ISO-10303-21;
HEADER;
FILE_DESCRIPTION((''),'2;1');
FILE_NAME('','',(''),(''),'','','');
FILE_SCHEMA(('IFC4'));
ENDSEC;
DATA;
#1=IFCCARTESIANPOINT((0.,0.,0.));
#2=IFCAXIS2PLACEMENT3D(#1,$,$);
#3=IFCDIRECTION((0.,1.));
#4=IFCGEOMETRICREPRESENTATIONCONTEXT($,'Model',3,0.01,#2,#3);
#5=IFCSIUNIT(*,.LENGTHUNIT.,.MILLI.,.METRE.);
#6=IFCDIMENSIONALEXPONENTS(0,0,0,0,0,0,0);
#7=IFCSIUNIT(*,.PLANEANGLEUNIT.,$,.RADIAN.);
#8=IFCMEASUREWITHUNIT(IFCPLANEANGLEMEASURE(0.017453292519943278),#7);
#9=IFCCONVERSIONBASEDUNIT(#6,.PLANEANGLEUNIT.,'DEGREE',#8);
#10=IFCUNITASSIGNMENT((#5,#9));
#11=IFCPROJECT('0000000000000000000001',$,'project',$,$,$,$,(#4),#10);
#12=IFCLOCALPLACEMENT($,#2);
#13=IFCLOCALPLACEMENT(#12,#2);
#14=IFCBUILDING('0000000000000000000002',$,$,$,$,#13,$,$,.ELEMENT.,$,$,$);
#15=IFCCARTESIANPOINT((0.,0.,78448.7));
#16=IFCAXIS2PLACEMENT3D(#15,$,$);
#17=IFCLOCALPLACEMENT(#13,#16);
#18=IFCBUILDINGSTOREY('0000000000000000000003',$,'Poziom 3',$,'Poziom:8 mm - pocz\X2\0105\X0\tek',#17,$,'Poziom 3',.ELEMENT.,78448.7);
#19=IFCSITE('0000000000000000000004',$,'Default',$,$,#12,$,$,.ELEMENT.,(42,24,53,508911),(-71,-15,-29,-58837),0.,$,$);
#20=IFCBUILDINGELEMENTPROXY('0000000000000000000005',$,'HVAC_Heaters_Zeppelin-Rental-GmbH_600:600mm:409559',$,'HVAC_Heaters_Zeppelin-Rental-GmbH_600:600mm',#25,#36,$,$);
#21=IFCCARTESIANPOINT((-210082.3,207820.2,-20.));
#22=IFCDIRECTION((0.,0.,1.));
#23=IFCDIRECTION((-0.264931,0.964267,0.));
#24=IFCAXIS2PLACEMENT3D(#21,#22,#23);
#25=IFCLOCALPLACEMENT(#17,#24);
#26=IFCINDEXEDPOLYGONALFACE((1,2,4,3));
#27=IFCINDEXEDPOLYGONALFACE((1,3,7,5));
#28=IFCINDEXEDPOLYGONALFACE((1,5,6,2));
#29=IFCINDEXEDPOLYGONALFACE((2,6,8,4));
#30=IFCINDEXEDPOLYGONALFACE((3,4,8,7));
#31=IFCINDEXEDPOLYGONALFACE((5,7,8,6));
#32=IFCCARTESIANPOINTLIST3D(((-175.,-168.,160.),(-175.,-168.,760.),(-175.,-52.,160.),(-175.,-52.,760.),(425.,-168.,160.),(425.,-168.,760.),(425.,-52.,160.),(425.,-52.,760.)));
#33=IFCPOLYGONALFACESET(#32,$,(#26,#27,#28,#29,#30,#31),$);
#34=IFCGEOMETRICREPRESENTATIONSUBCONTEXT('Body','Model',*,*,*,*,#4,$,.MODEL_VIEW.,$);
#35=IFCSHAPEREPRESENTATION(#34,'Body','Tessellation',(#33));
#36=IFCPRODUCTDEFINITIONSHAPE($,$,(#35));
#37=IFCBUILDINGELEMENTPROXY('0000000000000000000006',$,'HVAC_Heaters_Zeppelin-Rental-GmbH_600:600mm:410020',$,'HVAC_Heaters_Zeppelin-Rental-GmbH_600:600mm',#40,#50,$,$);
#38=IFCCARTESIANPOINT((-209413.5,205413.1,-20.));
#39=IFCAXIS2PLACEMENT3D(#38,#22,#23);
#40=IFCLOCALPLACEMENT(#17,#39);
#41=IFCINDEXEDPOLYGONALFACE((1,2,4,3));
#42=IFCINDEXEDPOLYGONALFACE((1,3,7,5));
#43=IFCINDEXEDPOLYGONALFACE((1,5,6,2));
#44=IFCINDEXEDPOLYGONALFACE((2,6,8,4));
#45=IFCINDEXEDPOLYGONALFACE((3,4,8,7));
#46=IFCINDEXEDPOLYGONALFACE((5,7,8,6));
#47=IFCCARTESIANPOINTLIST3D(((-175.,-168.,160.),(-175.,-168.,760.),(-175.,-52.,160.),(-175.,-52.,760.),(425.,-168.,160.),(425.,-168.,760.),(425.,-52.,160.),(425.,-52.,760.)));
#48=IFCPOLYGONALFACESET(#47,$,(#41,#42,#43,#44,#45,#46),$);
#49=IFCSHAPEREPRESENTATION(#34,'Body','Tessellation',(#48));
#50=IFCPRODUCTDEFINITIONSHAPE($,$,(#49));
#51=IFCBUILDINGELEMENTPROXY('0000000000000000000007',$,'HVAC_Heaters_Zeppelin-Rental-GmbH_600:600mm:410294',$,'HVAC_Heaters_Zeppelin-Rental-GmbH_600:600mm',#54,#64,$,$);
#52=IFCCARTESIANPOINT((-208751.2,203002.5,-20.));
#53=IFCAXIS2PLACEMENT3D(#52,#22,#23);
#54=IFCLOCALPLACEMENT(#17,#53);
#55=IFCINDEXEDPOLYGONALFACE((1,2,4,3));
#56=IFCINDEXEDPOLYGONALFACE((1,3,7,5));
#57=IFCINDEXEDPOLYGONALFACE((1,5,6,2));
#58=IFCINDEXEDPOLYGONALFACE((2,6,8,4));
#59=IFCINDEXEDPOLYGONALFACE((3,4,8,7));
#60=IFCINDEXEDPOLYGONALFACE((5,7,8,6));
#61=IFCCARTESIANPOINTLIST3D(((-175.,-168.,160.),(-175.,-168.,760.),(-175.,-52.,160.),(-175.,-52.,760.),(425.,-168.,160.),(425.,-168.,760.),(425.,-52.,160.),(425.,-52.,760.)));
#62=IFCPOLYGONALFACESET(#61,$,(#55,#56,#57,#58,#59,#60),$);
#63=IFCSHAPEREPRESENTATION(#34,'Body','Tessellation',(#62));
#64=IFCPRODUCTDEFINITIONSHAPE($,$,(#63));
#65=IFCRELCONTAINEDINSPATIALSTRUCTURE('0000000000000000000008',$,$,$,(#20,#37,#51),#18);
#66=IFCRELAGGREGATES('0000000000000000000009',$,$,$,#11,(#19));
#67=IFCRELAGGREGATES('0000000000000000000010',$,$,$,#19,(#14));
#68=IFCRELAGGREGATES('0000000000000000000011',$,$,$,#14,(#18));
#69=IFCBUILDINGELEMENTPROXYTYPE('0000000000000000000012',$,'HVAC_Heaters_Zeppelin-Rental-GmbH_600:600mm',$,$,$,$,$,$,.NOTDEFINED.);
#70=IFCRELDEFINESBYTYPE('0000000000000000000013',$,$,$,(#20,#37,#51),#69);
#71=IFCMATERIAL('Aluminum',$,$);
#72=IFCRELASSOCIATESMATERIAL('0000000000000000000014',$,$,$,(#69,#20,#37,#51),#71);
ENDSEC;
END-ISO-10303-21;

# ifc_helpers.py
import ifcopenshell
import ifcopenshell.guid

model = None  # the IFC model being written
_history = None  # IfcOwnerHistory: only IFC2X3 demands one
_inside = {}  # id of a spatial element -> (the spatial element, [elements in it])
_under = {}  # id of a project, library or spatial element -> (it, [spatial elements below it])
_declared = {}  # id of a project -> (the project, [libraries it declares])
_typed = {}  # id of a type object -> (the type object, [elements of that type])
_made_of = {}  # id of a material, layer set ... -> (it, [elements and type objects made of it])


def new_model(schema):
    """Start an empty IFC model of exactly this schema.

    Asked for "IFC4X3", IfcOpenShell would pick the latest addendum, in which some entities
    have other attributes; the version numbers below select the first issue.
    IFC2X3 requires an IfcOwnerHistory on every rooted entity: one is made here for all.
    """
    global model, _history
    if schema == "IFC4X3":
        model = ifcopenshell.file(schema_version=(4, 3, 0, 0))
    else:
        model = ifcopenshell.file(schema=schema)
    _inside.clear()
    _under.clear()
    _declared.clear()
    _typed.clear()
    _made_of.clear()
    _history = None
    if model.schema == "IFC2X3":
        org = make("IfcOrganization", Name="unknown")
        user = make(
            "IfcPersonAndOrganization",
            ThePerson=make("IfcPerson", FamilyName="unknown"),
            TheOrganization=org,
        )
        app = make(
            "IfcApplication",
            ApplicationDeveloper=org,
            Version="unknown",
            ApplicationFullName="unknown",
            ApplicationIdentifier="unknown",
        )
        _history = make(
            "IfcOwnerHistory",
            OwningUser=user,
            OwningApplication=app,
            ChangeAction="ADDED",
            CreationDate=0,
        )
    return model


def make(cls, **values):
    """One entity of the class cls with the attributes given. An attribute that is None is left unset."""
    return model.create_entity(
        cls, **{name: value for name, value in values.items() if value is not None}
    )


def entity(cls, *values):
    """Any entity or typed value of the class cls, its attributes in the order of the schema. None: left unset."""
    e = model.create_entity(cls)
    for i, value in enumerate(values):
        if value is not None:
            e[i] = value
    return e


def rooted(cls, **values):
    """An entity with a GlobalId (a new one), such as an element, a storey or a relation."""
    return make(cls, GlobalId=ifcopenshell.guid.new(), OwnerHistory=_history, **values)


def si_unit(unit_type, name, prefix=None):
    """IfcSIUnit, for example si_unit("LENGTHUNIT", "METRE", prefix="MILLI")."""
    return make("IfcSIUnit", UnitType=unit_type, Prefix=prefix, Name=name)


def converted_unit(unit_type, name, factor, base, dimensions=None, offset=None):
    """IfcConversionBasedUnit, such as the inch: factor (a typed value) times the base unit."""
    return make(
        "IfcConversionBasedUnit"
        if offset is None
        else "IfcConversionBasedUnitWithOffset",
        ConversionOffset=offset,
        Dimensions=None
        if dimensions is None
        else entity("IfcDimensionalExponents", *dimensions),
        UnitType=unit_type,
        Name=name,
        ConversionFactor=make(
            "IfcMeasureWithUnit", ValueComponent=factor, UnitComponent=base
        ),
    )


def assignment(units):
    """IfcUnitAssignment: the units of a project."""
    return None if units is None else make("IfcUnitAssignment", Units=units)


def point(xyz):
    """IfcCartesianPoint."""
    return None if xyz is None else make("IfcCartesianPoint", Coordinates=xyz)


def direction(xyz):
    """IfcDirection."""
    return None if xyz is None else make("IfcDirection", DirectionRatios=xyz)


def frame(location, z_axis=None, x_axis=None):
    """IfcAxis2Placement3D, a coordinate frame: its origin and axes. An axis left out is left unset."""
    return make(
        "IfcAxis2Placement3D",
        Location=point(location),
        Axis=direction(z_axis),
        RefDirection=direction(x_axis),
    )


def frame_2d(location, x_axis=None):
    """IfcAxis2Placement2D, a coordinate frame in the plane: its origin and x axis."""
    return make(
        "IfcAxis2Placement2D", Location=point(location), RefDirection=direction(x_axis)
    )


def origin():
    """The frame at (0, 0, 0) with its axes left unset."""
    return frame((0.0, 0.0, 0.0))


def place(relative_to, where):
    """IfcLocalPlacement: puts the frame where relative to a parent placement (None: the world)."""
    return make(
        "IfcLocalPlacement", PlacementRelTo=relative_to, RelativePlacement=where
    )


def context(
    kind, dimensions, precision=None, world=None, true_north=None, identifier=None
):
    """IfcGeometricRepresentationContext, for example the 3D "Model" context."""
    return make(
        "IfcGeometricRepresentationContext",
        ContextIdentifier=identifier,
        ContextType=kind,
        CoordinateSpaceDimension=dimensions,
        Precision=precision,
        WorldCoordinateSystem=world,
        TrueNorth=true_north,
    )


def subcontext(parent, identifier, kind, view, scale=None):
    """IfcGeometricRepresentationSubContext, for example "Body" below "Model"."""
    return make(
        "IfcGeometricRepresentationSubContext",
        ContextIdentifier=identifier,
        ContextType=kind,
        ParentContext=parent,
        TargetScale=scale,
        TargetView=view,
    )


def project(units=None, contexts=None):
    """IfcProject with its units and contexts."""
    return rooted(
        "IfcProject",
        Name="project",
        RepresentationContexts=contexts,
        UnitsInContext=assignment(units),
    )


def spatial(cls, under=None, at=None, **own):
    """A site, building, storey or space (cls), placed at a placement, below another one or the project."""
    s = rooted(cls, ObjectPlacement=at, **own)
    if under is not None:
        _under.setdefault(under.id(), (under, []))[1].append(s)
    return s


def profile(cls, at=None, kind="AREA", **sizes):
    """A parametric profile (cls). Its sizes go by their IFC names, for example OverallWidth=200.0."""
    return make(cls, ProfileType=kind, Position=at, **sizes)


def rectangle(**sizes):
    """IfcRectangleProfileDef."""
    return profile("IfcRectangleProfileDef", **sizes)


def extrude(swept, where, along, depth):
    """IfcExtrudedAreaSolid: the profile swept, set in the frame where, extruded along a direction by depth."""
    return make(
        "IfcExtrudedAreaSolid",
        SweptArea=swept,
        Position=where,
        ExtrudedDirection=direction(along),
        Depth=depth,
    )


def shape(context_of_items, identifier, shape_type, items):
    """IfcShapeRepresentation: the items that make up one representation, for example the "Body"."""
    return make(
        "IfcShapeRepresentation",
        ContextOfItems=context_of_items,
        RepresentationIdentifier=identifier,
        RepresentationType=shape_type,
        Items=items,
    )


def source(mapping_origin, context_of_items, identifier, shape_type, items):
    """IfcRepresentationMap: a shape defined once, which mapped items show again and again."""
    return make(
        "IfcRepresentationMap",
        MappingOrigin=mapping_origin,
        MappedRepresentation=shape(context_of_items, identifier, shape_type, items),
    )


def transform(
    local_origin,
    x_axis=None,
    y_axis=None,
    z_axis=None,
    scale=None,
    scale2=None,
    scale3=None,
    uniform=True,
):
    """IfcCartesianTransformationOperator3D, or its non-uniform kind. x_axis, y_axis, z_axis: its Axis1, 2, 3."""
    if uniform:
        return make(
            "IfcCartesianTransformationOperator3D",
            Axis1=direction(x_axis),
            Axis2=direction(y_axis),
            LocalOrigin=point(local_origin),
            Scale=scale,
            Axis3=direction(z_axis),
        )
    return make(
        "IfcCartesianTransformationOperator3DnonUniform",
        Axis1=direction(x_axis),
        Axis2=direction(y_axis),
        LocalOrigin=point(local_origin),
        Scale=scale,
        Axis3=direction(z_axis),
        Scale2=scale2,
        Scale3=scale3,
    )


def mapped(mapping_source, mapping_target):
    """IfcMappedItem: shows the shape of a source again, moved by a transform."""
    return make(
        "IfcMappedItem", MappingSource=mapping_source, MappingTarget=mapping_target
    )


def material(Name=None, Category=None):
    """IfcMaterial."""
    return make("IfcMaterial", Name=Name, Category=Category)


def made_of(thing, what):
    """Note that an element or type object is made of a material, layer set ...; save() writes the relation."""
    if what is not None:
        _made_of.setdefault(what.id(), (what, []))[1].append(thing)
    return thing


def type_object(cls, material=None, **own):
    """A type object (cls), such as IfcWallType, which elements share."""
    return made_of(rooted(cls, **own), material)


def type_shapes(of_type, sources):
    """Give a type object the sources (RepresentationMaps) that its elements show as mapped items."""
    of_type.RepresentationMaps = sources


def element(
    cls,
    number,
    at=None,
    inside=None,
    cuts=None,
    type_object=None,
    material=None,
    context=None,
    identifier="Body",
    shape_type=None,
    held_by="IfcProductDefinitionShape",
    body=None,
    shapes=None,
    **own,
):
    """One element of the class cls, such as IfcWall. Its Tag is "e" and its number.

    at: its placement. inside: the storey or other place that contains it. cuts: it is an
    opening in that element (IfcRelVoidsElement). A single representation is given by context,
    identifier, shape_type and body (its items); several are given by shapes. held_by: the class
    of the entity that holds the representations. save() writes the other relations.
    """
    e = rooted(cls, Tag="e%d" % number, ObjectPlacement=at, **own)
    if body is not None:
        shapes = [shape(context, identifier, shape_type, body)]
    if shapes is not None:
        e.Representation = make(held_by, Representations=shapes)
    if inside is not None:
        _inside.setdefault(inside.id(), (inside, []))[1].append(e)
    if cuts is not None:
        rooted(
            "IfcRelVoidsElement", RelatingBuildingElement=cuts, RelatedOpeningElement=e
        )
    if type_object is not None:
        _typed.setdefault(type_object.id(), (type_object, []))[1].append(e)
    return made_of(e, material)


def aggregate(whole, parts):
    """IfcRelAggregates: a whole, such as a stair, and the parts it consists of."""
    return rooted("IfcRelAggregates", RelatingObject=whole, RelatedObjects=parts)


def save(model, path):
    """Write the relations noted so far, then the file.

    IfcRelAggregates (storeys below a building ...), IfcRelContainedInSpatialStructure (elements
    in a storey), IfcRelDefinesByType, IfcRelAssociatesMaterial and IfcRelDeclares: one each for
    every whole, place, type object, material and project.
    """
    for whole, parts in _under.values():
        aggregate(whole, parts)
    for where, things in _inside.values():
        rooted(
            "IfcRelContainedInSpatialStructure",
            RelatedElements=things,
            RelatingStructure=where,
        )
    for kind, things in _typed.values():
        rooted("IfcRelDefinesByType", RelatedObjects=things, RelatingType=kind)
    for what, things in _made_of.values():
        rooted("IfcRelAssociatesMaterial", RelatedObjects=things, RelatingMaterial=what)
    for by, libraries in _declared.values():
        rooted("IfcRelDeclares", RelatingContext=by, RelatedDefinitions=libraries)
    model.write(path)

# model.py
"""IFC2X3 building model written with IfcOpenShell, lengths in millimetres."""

from ifc_helpers import new_model, entity, si_unit, converted_unit, direction, frame, frame_2d, origin, place, context, subcontext, project, spatial, rectangle, extrude, source, transform, mapped, material, type_object, type_shapes, element, save


model = new_model("IFC2X3")

# Units and contexts
model_context = context("Model", 3, precision=0.01, world=origin(), true_north=direction((0.0, 1.0)))
body_context = subcontext(model_context, "Body", "Model", "MODEL_VIEW")
ifc_project = project(units=[si_unit("LENGTHUNIT", "METRE", prefix="MILLI"), converted_unit("PLANEANGLEUNIT", "DEGREE", entity("IfcPlaneAngleMeasure", 0.017453292519943278), si_unit("PLANEANGLEUNIT", "RADIAN"), dimensions=[0, 0, 0, 0, 0, 0, 0])], contexts=[model_context])

# Site, building, storey
site_placement = place(None, origin())
site = spatial("IfcSite", under=ifc_project, at=site_placement, Name="Default", CompositionType="ELEMENT", RefLatitude=(42, 24, 53, 508911), RefLongitude=(-71, -15, -29, -58837), RefElevation=0.0)
building_placement = place(site_placement, origin())
building = spatial("IfcBuilding", under=site, at=building_placement, CompositionType="ELEMENT")
storey_placement = place(building_placement, frame((0.0, 0.0, 78448.7)))
storey = spatial("IfcBuildingStorey", under=building, at=storey_placement, Name="Poziom 3", ObjectType="Poziom:8 mm - początek", LongName="Poziom 3", CompositionType="ELEMENT", Elevation=78448.7)

# Shared definitions
ifc_material_1 = material(Name="Aluminum")

# Building element proxies
building_element_proxy_type = type_object("IfcBuildingElementProxyType", Name="HVAC_Heaters_Zeppelin-Rental-GmbH_600:600mm", PredefinedType="NOTDEFINED", material=ifc_material_1)
shared_shape_1 = source(origin(), body_context, "Body", "SweptSolid", [
    extrude(rectangle(XDim=116.0, YDim=600.0, at=frame_2d((0.0, 0.0), x_axis=(1.0, 0.0))), frame((125.0, -110.0, 160.0), z_axis=(0.0, 0.0, 1.0), x_axis=(0.0, 1.0, 0.0)), (0.0, 0.0, 1.0), 600.0),
])
type_shapes(building_element_proxy_type, [shared_shape_1])
for number, where, z_axis, x_axis, name in (
    (1, (-210082.3, 207820.2, -20.0), (0.0, 0.0, 1.0), (-0.264931, 0.964267, 0.0), "HVAC_Heaters_Zeppelin-Rental-GmbH_600:600mm:409559"),
    (2, (-209413.5, 205413.1, -20.0), (0.0, 0.0, 1.0), (-0.264931, 0.964267, 0.0), "HVAC_Heaters_Zeppelin-Rental-GmbH_600:600mm:410020"),
    (3, (-208751.2, 203002.5, -20.0), (0.0, 0.0, 1.0), (-0.264931, 0.964267, 0.0), "HVAC_Heaters_Zeppelin-Rental-GmbH_600:600mm:410294"),
):
    element("IfcBuildingElementProxy", number, at=place(storey_placement, frame(where, z_axis=z_axis, x_axis=x_axis)), inside=storey, type_object=building_element_proxy_type, material=ifc_material_1, Name=name, ObjectType="HVAC_Heaters_Zeppelin-Rental-GmbH_600:600mm", context=body_context, shape_type="MappedRepresentation", body=[
        mapped(shared_shape_1, transform((0.0, 0.0, 0.0), scale=1.0)),
    ])

save(model, "model.ifc")
